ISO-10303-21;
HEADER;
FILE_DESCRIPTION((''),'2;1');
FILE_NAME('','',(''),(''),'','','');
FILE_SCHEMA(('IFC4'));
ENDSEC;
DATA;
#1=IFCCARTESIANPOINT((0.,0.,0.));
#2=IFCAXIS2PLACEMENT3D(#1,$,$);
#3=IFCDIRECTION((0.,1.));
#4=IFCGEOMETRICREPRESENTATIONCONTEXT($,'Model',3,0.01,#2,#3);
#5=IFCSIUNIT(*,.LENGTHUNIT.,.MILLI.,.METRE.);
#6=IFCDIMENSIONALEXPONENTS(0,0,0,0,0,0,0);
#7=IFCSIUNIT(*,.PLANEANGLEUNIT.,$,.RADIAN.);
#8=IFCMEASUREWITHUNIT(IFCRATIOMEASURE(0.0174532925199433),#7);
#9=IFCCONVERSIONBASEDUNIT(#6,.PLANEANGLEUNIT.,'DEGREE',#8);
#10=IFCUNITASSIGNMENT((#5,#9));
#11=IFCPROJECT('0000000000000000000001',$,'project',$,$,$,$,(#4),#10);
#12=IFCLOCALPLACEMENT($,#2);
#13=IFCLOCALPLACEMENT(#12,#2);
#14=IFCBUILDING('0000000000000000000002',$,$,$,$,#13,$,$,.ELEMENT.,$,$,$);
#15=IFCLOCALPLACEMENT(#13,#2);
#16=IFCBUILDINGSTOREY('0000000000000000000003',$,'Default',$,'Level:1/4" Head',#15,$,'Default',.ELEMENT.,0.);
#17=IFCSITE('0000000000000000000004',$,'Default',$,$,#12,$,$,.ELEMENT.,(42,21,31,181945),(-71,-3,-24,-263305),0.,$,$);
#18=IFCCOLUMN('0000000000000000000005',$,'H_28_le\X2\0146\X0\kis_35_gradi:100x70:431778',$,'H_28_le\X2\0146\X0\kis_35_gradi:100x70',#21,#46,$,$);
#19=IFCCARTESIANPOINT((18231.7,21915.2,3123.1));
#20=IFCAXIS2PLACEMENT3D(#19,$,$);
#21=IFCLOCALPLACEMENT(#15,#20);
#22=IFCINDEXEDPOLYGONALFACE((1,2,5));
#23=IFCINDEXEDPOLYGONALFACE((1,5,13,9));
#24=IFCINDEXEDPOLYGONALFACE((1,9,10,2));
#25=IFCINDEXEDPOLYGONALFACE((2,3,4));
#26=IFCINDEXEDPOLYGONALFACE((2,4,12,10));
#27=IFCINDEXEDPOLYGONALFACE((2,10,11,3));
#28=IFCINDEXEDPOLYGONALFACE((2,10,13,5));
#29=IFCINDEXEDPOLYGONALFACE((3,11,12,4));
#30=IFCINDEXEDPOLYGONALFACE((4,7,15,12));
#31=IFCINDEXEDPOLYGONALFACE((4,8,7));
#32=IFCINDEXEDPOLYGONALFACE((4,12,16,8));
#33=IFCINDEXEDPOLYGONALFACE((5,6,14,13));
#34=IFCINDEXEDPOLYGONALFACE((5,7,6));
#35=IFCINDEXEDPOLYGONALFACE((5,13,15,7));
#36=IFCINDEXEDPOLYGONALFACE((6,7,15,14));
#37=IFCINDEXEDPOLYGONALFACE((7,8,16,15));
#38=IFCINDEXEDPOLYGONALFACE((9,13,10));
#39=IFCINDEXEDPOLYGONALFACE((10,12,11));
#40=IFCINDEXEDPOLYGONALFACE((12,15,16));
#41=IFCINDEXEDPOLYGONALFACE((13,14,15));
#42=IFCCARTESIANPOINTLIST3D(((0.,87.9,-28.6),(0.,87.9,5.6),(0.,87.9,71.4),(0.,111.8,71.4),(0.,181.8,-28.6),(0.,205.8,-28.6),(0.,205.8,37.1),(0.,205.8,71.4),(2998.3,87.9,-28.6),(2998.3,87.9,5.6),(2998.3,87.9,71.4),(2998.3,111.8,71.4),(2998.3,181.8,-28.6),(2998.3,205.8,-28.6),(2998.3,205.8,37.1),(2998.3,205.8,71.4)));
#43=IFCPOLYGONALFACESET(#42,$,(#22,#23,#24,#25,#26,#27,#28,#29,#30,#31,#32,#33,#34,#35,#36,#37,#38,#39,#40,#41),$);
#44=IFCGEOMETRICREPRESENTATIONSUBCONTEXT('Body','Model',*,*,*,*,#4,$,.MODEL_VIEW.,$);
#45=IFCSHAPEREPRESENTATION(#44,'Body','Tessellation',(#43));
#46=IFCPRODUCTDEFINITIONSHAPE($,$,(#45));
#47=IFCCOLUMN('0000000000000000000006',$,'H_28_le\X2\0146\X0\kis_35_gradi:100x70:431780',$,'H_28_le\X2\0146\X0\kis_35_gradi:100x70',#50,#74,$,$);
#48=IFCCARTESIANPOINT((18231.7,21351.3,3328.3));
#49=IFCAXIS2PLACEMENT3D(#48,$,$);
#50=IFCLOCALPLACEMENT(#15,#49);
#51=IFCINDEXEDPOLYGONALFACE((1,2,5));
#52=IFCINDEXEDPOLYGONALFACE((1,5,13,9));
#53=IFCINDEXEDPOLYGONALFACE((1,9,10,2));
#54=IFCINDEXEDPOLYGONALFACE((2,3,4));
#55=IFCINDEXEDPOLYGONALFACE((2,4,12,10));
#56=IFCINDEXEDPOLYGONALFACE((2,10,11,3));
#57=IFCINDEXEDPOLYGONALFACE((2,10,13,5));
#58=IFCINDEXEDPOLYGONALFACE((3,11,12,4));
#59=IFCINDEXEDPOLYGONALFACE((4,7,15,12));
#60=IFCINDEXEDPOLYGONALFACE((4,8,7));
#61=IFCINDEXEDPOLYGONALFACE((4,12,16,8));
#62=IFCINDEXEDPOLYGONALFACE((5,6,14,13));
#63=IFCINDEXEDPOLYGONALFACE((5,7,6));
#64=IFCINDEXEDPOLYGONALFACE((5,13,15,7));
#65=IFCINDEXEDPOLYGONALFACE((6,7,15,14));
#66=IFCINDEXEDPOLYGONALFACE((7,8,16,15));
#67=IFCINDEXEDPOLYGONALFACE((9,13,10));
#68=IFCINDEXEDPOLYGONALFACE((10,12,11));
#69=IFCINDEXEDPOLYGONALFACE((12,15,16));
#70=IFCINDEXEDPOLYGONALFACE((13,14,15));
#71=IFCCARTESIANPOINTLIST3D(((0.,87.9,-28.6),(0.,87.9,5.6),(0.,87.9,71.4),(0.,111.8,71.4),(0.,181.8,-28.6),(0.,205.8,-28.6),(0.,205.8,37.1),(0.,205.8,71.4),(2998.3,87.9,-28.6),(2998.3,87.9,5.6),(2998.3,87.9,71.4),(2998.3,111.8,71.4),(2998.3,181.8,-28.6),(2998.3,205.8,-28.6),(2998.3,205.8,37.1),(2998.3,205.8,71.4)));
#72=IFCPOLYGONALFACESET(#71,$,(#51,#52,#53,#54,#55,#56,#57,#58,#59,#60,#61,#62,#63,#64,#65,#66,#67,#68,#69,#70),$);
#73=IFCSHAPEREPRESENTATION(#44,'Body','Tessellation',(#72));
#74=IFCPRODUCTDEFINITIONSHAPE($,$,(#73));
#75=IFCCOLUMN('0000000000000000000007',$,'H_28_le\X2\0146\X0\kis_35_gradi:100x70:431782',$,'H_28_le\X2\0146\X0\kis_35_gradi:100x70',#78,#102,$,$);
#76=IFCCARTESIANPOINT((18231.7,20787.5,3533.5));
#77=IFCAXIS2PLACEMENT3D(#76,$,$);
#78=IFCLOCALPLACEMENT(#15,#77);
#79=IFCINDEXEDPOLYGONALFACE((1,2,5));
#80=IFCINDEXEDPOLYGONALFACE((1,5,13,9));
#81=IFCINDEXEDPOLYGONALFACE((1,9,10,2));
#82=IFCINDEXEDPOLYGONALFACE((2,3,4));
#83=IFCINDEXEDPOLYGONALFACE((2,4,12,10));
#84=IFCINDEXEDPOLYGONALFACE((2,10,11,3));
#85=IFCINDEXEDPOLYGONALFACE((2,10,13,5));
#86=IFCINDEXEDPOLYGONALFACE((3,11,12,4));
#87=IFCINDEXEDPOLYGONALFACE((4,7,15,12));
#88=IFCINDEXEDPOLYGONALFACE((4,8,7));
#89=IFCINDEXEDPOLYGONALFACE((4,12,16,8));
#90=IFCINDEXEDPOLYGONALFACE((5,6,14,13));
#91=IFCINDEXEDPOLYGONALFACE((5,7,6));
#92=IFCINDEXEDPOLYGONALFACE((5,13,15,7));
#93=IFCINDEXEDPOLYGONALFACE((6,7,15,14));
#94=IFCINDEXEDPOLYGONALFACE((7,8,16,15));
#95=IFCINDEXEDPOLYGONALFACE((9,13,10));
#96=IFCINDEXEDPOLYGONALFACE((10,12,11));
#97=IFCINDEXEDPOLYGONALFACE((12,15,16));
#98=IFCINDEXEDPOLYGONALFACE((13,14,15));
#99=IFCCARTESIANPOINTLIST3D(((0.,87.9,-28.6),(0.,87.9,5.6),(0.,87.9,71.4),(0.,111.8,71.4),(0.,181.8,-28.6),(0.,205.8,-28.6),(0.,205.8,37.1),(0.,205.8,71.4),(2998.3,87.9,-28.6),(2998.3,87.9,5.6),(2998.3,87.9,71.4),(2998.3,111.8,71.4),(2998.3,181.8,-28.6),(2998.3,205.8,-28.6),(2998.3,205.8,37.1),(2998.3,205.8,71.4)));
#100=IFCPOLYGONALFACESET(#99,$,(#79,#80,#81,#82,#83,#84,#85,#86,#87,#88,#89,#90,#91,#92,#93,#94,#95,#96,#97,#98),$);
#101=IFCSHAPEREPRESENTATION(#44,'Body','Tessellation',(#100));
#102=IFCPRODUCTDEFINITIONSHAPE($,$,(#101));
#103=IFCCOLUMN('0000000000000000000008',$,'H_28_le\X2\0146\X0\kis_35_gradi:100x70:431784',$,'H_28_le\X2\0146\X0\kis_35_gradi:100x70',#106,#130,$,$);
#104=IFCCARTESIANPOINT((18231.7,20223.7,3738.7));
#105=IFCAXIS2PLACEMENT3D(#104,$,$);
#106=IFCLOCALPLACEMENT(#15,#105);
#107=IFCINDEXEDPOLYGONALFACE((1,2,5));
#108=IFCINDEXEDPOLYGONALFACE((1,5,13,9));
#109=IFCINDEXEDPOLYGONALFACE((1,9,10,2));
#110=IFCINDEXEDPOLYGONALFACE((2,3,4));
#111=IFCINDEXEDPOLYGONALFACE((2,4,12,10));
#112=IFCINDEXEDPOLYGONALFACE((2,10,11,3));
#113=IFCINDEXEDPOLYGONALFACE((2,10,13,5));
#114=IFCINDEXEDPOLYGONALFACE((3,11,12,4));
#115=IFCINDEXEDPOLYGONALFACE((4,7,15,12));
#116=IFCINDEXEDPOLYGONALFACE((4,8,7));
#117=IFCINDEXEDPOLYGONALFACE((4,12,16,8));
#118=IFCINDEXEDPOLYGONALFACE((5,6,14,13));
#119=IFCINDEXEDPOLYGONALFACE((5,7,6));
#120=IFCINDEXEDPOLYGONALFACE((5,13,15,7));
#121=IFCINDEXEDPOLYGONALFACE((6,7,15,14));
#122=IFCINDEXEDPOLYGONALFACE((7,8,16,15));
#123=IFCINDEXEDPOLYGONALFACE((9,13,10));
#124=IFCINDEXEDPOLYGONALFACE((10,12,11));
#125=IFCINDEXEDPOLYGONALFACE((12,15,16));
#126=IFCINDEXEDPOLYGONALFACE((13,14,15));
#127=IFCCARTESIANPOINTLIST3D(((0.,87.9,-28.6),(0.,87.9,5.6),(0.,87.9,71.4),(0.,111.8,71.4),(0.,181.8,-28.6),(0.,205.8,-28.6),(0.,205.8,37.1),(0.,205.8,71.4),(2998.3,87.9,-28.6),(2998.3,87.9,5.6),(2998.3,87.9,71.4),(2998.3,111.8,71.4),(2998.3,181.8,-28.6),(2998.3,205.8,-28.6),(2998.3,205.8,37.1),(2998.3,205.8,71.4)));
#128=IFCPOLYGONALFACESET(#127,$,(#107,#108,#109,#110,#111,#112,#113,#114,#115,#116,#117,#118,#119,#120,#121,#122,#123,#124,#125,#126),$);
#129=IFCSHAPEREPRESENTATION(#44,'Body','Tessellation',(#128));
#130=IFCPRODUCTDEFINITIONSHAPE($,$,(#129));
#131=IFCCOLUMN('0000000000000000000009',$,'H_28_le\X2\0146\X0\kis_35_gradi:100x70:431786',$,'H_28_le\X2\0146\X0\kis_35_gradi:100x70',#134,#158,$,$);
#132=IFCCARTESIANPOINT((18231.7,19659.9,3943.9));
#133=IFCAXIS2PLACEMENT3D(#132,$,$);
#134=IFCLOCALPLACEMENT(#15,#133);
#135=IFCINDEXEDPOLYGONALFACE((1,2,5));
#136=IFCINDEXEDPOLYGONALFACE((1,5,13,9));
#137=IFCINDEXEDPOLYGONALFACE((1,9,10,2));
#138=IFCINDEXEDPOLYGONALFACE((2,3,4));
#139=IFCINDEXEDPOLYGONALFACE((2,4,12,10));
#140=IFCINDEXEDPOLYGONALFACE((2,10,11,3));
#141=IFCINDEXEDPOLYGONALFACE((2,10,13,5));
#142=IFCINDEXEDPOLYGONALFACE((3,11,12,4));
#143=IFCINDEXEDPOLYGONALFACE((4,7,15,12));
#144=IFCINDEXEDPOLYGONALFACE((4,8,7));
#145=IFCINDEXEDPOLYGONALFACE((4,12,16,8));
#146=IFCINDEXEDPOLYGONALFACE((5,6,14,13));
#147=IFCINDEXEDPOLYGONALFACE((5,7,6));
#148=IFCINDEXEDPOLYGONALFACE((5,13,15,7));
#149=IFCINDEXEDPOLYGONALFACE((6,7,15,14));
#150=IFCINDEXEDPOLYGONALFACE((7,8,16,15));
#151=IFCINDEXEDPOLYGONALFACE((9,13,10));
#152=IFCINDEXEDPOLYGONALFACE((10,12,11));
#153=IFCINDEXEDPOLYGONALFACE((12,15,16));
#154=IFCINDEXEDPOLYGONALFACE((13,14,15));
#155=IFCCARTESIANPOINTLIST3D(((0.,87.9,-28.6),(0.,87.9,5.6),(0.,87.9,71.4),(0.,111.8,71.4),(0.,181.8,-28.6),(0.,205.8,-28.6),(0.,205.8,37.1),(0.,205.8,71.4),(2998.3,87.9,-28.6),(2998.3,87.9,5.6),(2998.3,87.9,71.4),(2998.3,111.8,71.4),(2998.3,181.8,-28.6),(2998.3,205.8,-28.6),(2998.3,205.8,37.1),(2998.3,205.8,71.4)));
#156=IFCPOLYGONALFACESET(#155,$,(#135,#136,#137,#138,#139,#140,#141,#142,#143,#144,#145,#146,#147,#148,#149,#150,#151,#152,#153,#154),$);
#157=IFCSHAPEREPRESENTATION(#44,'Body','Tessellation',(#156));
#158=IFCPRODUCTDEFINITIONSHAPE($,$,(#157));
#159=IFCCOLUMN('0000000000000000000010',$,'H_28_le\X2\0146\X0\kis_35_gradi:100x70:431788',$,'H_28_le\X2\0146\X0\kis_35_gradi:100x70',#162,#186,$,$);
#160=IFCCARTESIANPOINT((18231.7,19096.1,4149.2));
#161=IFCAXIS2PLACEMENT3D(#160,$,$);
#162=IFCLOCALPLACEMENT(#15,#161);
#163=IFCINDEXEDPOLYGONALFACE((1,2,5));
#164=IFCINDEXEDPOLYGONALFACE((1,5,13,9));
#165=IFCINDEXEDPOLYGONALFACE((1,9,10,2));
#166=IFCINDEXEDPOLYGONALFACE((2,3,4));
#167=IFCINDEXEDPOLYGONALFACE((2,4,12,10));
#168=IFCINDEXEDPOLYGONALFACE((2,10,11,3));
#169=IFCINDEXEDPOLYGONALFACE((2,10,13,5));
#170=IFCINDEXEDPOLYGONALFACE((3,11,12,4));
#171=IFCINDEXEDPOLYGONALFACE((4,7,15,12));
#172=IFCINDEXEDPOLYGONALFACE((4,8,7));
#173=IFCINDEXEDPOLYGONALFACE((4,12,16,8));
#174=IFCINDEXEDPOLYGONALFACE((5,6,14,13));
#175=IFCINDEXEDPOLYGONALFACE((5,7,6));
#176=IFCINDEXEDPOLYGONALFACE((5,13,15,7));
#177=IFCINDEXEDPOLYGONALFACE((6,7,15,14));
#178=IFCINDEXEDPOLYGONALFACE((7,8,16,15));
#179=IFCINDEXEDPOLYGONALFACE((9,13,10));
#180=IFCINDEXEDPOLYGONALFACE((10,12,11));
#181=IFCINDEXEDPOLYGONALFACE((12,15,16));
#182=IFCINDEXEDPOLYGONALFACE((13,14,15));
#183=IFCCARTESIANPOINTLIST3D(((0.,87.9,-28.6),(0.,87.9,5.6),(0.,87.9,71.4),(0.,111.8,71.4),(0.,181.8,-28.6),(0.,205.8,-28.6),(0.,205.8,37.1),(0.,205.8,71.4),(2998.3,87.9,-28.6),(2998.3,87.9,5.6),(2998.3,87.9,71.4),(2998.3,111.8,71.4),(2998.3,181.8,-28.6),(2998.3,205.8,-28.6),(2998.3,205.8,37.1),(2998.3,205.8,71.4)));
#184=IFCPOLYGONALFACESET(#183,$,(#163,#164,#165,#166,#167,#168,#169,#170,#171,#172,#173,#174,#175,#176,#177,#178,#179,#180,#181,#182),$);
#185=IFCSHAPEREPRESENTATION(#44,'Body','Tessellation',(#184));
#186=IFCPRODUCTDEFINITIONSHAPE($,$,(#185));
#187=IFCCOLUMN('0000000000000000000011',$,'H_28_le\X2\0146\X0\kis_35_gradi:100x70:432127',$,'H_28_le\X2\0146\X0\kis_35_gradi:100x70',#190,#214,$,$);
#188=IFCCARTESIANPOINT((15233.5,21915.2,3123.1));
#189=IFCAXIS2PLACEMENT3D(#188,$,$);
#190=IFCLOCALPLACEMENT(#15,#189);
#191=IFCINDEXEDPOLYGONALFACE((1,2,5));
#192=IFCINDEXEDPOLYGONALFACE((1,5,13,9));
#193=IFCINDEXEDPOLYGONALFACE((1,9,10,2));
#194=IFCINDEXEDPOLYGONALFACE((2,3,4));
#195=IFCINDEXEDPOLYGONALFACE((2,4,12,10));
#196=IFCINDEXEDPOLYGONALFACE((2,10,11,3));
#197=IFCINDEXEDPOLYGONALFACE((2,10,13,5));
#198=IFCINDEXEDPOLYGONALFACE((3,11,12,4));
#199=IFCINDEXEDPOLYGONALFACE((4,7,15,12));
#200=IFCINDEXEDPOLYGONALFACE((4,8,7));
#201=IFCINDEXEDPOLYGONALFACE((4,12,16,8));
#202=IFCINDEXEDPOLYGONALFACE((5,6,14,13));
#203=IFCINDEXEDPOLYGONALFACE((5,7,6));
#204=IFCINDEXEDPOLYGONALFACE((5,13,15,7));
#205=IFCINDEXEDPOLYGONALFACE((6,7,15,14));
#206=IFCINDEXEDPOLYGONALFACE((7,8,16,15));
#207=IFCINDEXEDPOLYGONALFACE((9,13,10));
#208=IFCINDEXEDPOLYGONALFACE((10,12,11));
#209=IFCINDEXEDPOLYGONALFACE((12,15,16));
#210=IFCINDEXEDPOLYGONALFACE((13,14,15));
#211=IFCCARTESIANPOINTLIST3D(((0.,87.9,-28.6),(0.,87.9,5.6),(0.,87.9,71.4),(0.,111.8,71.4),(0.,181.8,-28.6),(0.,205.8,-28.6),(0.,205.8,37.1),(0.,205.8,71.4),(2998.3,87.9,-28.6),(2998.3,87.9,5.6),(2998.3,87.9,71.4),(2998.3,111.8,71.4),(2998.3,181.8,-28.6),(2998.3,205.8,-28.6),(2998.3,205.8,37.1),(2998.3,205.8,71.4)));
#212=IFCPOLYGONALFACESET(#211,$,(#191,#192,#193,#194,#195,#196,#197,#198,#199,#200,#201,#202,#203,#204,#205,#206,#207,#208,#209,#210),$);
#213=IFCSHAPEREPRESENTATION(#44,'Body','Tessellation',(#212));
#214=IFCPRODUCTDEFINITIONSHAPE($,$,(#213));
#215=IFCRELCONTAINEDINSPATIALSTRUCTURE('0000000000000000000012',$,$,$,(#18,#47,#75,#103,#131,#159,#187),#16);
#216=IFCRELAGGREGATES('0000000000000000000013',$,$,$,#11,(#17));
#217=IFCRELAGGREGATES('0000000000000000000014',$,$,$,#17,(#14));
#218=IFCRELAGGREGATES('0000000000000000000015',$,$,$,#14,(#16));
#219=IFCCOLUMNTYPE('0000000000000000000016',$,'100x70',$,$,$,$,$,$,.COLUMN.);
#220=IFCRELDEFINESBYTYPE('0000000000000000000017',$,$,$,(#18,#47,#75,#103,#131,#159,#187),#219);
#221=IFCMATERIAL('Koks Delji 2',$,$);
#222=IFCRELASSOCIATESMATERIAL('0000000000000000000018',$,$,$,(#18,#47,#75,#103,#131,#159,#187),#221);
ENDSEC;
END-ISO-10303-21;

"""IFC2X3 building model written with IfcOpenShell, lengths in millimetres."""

from ifc_helpers import new_model, entity, si_unit, converted_unit, direction, frame, frame_2d, origin, place, context, subcontext, project, spatial, rectangle, extrude, boolean, source, transform, mapped, material, type_object, type_shapes, element, save


model = new_model("IFC2X3")

# Units and contexts
model_context = context("Model", 3, precision=0.01, world=origin(), true_north=direction((0.0, 1.0)))
body_context = subcontext(model_context, "Body", "Model", "MODEL_VIEW")
ifc_project = project(units=[si_unit("LENGTHUNIT", "METRE", prefix="MILLI"), converted_unit("PLANEANGLEUNIT", "DEGREE", entity("IfcRatioMeasure", 0.0174532925199433), si_unit("PLANEANGLEUNIT", "RADIAN"), dimensions=[0, 0, 0, 0, 0, 0, 0])], contexts=[model_context])

# Site, building, storey
site_placement = place(None, origin())
site = spatial("IfcSite", under=ifc_project, at=site_placement, Name="Default", CompositionType="ELEMENT", RefLatitude=(42, 21, 31, 181945), RefLongitude=(-71, -3, -24, -263305), RefElevation=0.0)
building_placement = place(site_placement, origin())
building = spatial("IfcBuilding", under=site, at=building_placement, CompositionType="ELEMENT")
storey_placement = place(building_placement, origin())
storey = spatial("IfcBuildingStorey", under=building, at=storey_placement, Name="Default", ObjectType="Level:1/4\" Head", LongName="Default", CompositionType="ELEMENT", Elevation=0.0)

# Columns
ifc_material_1 = material(Name="Koks Delji 2")
column_type = type_object("IfcColumnType", Name="100x70", PredefinedType="COLUMN")
shared_shape_1 = source(origin(), body_context, "Body", "CSG", [
    boolean("DIFFERENCE", extrude(rectangle(XDim=2998.3, YDim=117.9, at=frame_2d((0.0, 0.0), x_axis=(1.0, 0.0))), frame((1499.1, 146.8, -28.6)), (0.0, 0.0, 1.0), 100.0), extrude(rectangle(XDim=70.0, YDim=100.0, at=frame_2d((0.0, 0.0), x_axis=(0.0, 1.0))), frame((2998.3, 146.8, 21.4), z_axis=(1.0, 0.0, 0.0), x_axis=(0.0, 0.939693, -0.34202)), (0.0, 0.0, -1.0), 2998.3)),
])
type_shapes(column_type, [shared_shape_1])
for number, where, name in (
    (1, (18231.7, 21915.2, 3123.1), "H_28_leņkis_35_gradi:100x70:431778"),
    (2, (18231.7, 21351.3, 3328.3), "H_28_leņkis_35_gradi:100x70:431780"),
    (3, (18231.7, 20787.5, 3533.5), "H_28_leņkis_35_gradi:100x70:431782"),
    (4, (18231.7, 20223.7, 3738.7), "H_28_leņkis_35_gradi:100x70:431784"),
    (5, (18231.7, 19659.9, 3943.9), "H_28_leņkis_35_gradi:100x70:431786"),
    (6, (18231.7, 19096.1, 4149.2), "H_28_leņkis_35_gradi:100x70:431788"),
    (7, (15233.5, 21915.2, 3123.1), "H_28_leņkis_35_gradi:100x70:432127"),
):
    element("IfcColumn", number, at=place(storey_placement, frame(where)), inside=storey, type_object=column_type, material=ifc_material_1, Name=name, ObjectType="H_28_leņkis_35_gradi:100x70", context=body_context, shape_type="MappedRepresentation", body=[
        mapped(shared_shape_1, transform((0.0, 0.0, 0.0), scale=1.0)),
    ])

save(model, "model.ifc")
